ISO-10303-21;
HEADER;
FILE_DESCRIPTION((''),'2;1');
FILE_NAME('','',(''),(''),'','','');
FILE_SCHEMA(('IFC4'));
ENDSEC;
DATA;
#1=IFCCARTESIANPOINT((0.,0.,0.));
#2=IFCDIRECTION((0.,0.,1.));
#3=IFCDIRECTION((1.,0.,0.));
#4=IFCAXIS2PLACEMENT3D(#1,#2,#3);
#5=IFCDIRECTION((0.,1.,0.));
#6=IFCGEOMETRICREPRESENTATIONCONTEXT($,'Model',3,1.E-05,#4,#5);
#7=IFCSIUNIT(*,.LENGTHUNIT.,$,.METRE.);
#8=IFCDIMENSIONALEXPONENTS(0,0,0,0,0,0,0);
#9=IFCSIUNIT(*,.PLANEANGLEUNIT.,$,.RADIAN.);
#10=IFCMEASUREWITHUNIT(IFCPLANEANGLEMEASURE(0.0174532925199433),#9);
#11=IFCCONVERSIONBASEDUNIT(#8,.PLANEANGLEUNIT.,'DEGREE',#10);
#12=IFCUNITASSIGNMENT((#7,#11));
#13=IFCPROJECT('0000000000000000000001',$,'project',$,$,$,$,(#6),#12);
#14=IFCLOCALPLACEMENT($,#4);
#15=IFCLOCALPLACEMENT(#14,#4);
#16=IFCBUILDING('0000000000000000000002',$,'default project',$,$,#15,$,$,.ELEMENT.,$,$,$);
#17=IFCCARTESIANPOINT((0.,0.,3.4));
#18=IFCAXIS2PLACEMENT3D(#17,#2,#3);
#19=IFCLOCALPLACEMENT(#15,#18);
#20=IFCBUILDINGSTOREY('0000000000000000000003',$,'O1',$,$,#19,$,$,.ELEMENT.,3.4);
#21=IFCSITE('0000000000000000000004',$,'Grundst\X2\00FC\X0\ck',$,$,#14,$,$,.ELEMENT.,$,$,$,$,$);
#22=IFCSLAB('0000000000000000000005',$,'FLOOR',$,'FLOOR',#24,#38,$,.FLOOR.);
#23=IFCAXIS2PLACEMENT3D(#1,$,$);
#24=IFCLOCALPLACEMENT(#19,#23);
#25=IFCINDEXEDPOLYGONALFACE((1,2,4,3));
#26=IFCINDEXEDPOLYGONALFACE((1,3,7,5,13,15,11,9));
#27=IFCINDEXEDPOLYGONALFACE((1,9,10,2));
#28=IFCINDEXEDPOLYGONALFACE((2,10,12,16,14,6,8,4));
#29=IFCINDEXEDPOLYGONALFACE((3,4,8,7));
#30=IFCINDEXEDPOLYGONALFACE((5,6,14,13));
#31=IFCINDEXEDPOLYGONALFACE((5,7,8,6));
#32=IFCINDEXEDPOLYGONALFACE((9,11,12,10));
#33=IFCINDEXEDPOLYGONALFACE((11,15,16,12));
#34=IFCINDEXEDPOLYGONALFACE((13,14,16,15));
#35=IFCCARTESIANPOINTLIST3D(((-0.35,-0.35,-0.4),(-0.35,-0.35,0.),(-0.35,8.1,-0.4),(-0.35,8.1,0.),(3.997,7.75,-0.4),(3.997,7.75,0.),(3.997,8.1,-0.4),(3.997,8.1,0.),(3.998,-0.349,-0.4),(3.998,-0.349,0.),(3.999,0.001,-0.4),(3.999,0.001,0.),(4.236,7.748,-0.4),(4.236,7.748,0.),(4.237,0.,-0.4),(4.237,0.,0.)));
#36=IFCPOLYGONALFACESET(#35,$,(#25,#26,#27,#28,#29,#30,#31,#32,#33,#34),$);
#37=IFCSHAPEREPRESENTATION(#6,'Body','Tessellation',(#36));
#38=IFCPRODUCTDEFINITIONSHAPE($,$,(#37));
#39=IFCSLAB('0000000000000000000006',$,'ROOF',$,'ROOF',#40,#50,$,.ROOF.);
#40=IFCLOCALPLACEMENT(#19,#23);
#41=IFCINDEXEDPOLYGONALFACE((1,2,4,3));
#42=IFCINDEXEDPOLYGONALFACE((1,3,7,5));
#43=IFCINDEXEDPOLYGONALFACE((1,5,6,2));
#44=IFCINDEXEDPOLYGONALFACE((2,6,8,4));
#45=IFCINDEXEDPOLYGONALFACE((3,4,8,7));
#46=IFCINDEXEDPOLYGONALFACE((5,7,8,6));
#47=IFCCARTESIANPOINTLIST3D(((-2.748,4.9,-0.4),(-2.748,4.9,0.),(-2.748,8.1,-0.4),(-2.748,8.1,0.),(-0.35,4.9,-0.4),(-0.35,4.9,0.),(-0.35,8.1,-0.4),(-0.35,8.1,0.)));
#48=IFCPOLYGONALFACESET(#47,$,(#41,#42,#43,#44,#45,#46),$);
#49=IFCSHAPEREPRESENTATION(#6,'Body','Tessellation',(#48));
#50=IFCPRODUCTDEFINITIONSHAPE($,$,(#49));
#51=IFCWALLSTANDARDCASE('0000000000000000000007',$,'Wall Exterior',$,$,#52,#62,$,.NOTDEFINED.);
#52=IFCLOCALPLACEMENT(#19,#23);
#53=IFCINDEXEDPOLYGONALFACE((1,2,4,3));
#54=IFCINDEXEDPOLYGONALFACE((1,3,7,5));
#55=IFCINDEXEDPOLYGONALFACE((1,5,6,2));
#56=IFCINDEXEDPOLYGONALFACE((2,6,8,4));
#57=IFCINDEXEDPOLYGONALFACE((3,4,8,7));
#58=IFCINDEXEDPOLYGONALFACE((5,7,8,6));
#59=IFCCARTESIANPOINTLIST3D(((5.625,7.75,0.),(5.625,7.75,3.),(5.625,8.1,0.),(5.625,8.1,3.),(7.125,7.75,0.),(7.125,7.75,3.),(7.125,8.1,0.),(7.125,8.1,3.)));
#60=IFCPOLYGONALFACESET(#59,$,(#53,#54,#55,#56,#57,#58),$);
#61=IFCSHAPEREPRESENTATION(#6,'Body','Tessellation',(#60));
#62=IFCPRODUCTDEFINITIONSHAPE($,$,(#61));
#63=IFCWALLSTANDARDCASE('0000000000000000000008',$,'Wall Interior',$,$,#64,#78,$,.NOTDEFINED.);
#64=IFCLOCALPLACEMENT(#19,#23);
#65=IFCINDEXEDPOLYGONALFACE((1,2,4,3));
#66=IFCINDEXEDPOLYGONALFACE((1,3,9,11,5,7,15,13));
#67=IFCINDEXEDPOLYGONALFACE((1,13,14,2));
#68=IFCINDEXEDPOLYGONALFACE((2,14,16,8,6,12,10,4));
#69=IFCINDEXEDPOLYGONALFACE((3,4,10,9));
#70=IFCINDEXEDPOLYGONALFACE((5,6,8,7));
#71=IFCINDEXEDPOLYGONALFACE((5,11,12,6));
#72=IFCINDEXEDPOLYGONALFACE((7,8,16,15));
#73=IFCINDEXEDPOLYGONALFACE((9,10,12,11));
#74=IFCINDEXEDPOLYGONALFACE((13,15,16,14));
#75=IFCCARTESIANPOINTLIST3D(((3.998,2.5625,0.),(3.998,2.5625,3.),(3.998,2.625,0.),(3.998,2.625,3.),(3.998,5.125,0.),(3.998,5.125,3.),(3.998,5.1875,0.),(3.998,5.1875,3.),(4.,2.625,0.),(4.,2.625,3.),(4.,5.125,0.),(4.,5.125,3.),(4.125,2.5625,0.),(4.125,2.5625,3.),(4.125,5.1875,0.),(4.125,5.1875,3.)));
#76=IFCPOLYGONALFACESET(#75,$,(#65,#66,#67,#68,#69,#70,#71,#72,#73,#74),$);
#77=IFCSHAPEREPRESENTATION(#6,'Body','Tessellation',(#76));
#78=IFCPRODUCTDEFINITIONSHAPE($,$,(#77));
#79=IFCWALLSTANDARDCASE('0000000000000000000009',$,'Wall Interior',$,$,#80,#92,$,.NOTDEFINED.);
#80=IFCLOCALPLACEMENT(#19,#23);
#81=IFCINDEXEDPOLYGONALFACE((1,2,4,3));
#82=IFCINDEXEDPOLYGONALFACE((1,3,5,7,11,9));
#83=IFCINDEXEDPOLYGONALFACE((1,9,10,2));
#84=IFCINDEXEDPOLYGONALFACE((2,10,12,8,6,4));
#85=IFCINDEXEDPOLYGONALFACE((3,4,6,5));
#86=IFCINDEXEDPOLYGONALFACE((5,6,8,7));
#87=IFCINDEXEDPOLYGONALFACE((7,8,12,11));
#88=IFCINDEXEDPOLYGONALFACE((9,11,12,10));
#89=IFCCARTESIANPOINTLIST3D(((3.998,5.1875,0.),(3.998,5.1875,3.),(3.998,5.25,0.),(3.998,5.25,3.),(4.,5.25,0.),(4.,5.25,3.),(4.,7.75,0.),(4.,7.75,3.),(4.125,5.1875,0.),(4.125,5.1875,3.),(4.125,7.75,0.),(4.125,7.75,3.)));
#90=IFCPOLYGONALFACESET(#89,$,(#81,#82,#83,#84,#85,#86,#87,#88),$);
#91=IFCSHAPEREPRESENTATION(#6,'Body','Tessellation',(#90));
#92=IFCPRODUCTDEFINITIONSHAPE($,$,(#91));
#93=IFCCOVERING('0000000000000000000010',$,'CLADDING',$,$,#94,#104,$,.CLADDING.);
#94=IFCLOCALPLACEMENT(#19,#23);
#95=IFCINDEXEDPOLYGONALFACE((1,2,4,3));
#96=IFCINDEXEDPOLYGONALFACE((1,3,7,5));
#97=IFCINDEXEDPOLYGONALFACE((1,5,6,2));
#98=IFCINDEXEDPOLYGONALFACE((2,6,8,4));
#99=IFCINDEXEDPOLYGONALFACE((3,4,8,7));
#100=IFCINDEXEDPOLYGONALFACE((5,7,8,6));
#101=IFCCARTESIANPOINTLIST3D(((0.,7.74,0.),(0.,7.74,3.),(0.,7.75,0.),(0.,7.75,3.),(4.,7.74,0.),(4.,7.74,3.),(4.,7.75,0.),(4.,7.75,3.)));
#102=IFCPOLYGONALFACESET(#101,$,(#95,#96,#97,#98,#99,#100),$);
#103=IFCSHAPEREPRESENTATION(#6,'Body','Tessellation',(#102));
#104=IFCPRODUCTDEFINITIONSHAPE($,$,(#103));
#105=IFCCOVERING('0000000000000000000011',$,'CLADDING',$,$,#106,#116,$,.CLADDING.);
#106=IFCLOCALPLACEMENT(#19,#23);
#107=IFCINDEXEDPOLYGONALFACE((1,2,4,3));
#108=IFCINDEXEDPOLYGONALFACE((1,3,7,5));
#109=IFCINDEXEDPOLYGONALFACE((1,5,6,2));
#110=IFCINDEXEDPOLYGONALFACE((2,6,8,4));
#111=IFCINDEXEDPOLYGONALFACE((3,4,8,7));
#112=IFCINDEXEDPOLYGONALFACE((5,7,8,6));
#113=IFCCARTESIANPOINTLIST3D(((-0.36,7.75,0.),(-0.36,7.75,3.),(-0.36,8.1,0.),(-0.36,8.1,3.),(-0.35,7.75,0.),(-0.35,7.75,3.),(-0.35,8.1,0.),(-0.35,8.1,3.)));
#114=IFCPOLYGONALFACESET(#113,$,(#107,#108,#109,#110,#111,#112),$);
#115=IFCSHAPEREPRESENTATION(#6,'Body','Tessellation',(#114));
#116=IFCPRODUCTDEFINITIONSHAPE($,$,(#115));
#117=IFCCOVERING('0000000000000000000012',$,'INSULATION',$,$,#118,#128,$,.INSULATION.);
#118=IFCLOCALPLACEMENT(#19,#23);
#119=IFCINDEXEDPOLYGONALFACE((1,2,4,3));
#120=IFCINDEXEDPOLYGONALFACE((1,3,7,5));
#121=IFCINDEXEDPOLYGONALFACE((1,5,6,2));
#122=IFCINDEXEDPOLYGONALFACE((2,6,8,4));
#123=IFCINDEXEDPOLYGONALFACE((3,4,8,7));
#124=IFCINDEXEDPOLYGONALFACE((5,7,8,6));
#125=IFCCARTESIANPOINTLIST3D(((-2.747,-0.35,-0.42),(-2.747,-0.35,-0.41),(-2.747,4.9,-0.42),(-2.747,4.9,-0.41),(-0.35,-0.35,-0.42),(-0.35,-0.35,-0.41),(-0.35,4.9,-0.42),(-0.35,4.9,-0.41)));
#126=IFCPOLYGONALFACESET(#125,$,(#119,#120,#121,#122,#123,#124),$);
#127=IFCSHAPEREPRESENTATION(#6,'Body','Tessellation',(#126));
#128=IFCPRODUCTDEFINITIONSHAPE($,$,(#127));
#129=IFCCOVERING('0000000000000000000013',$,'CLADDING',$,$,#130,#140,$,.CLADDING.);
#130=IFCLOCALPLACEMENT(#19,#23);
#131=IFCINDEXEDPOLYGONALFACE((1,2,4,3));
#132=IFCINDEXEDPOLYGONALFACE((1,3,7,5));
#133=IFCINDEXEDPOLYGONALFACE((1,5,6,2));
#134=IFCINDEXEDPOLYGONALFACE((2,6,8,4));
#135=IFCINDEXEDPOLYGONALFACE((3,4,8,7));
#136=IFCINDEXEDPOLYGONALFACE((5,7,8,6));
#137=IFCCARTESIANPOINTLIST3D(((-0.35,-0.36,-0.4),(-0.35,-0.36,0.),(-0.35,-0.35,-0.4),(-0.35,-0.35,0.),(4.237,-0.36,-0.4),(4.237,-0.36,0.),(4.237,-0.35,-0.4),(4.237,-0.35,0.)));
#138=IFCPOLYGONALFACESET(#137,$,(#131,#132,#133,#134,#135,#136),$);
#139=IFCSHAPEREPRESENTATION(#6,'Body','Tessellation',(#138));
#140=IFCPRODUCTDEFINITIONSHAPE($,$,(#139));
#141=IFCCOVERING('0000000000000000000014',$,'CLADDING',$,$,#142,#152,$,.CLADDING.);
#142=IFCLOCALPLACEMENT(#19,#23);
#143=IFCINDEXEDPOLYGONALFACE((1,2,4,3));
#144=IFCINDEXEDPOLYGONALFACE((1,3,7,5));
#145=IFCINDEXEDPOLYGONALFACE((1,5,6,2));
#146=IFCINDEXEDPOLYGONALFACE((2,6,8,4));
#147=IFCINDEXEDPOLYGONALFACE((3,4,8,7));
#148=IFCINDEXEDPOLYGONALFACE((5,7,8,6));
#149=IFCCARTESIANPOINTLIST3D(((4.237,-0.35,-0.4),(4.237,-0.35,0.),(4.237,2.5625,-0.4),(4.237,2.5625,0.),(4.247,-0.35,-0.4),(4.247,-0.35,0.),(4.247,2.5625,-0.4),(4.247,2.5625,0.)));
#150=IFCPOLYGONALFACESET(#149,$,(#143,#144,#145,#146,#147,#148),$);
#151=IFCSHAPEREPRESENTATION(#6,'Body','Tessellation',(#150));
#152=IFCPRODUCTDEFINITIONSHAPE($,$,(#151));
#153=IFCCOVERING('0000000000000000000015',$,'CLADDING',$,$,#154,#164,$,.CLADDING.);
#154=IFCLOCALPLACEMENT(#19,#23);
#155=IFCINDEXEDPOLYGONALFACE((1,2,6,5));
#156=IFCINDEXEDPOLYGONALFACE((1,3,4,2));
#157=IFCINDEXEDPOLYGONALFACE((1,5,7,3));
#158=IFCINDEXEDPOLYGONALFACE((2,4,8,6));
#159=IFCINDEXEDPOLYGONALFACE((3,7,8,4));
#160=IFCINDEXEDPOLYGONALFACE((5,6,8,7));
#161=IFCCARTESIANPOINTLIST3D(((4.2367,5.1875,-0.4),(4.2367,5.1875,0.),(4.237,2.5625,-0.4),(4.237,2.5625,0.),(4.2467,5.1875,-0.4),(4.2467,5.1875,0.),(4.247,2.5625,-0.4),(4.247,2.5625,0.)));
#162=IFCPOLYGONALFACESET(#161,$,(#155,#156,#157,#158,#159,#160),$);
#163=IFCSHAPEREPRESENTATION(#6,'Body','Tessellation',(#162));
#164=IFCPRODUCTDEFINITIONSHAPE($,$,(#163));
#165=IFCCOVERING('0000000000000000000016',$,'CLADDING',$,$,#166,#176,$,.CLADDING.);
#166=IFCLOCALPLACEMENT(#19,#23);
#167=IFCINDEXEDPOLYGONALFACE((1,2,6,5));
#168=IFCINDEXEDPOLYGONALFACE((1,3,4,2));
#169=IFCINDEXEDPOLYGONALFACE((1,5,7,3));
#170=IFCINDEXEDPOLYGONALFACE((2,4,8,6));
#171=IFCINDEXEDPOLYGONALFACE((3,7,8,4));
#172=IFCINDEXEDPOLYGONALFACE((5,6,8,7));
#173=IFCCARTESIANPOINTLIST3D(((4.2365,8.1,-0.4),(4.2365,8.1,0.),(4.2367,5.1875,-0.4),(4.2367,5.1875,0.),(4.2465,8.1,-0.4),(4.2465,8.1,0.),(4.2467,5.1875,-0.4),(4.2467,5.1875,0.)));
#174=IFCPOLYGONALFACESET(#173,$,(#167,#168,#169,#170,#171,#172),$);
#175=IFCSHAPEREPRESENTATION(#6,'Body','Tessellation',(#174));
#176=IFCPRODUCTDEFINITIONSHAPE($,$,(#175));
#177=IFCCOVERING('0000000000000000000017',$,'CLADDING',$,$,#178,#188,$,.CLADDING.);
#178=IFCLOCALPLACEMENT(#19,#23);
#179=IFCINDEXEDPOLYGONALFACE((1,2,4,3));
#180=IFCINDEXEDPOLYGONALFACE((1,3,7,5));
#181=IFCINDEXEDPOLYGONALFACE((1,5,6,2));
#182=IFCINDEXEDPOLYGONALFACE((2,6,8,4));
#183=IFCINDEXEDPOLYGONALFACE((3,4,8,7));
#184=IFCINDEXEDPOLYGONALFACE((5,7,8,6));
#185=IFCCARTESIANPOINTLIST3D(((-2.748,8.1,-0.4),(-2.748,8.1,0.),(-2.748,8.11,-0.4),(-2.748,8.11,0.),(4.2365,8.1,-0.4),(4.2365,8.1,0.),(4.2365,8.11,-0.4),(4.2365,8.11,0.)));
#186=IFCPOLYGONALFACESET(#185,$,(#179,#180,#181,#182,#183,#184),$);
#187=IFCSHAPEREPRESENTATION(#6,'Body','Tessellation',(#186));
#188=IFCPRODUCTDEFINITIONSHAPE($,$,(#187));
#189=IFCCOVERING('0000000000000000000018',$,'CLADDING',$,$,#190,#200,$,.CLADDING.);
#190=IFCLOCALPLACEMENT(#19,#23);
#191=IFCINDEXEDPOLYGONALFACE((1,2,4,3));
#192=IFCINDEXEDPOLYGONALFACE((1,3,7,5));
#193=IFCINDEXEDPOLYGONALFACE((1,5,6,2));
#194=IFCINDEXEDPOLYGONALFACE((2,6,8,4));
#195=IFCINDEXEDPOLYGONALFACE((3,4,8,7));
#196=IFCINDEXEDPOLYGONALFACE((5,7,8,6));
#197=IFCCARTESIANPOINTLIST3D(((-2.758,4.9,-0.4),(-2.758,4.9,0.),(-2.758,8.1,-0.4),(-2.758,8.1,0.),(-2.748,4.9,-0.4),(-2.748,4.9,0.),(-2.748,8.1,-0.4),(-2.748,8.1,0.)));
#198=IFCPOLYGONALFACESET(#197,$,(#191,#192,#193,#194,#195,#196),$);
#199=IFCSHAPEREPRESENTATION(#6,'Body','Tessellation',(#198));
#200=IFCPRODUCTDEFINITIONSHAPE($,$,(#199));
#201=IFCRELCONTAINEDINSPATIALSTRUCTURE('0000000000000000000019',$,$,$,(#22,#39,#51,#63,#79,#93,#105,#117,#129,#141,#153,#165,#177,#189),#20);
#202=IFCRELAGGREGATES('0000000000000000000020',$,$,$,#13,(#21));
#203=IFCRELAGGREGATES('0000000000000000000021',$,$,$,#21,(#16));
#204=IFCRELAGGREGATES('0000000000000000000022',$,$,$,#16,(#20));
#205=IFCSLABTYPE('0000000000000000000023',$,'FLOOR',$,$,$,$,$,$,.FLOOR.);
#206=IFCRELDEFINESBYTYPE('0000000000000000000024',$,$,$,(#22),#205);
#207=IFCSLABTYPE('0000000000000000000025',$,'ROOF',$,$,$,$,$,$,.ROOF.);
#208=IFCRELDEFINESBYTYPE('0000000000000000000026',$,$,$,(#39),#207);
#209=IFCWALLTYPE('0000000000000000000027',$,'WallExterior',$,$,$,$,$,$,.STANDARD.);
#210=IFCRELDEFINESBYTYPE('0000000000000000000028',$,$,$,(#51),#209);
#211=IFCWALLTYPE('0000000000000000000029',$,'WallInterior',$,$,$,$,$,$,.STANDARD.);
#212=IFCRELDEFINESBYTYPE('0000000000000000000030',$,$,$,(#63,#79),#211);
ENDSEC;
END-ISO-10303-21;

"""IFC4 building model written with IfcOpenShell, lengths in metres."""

from ifc_helpers import new_model, entity, si_unit, converted_unit, direction, frame, origin_with_axes, place, context, project, spatial, polyline, outline, extrude, type_object, element, save


model = new_model("IFC4")

# Units and contexts
model_context = context("Model", 3, precision=1e-05, world=origin_with_axes(), true_north=direction((0.0, 1.0, 0.0)))
ifc_project = project(units=[si_unit("LENGTHUNIT", "METRE"), converted_unit("PLANEANGLEUNIT", "DEGREE", entity("IfcPlaneAngleMeasure", 0.0174532925199433), si_unit("PLANEANGLEUNIT", "RADIAN"), dimensions=[0, 0, 0, 0, 0, 0, 0])], contexts=[model_context])

# Site, building, storey
site_placement = place(None, origin_with_axes())
site = spatial("IfcSite", under=ifc_project, at=site_placement, Name="Grundstück", CompositionType="ELEMENT")
building_placement = place(site_placement, origin_with_axes())
building = spatial("IfcBuilding", under=site, at=building_placement, Name="default project", CompositionType="ELEMENT")
placement_1 = place(building_placement, frame((0.0, 0.0, 3.4), z_axis=(0.0, 0.0, 1.0), x_axis=(1.0, 0.0, 0.0)))
storey = spatial("IfcBuildingStorey", under=building, at=placement_1, Name="O1", CompositionType="ELEMENT", Elevation=3.4)

# Slabs
slab_type_1 = type_object("IfcSlabType", Name="FLOOR", PredefinedType="FLOOR")
slab_1_placement = place(placement_1, frame((0.0, 0.0, -0.4), z_axis=(0.0, 0.0, 1.0), x_axis=(1.0, 0.0, 0.0)))
element("IfcSlab", 1, at=slab_1_placement, inside=storey, type_object=slab_type_1, Name="FLOOR", ObjectType="FLOOR", PredefinedType="FLOOR", context=model_context, shape_type="SweptSolid", body=[
    extrude(outline(polyline([(4.237, 0.0), (4.236, 7.748), (3.997, 7.75), (3.997, 8.1), (-0.35, 8.1), (-0.35, -0.35), (3.998, -0.349), (3.999, 0.001), (4.237, 0.0)])), origin_with_axes(), (0.0, 0.0, 1.0), 0.4),
])
slab_type_2 = type_object("IfcSlabType", Name="ROOF", PredefinedType="ROOF")
slab_2_placement = place(placement_1, frame((0.0, 0.0, -0.4), z_axis=(0.0, 0.0, 1.0), x_axis=(1.0, 0.0, 0.0)))
element("IfcSlab", 2, at=slab_2_placement, inside=storey, type_object=slab_type_2, Name="ROOF", ObjectType="ROOF", PredefinedType="ROOF", context=model_context, shape_type="SweptSolid", body=[
    extrude(outline(polyline([(-0.35, 8.1), (-2.748, 8.1), (-2.748, 4.9), (-0.35, 4.9), (-0.35, 8.1)])), origin_with_axes(), (0.0, 0.0, 1.0), 0.4),
])

# Walls
wall_type_1 = type_object("IfcWallType", Name="WallExterior", PredefinedType="STANDARD")
placement_2 = place(placement_1, frame((5.625, 7.925, 0.0), z_axis=(0.0, 0.0, 1.0), x_axis=(1.0, 0.0, 0.0)))
element("IfcWallStandardCase", 3, at=placement_2, inside=storey, type_object=wall_type_1, Name="Wall Exterior", PredefinedType="NOTDEFINED", context=model_context, shape_type="SweptSolid", body=[
    extrude(outline(polyline([(1.5, 0.175), (0.0, 0.175), (0.0, -0.175), (1.5, -0.175), (1.5, 0.175)])), origin_with_axes(), (0.0, 0.0, 1.0), 3.0),
])
placement_3 = place(placement_1, frame((-0.175, 7.925, 0.0), z_axis=(0.0, 0.0, 1.0), x_axis=(1.0, 0.0, 0.0)))
wall_type_2 = type_object("IfcWallType", Name="WallInterior", PredefinedType="STANDARD")
wall_1_placement = place(placement_1, frame((4.0625, 2.5625, 0.0), z_axis=(0.0, 0.0, 1.0), x_axis=(0.0, 1.0, 0.0)))
element("IfcWallStandardCase", 4, at=wall_1_placement, inside=storey, type_object=wall_type_2, Name="Wall Interior", PredefinedType="NOTDEFINED", context=model_context, shape_type="SweptSolid", body=[
    extrude(outline(polyline([(2.5625, 0.0625), (0.0625, 0.0625), (0.0625, 0.0645), (0.0, 0.0645), (0.0, -0.0625), (2.625, -0.0625), (2.625, 0.0645), (2.5625, 0.0645), (2.5625, 0.0625)])), origin_with_axes(), (0.0, 0.0, 1.0), 3.0),
])
wall_2_placement = place(placement_1, frame((4.0625, 5.1875, 0.0), z_axis=(0.0, 0.0, 1.0), x_axis=(0.0, 1.0, 0.0)))
element("IfcWallStandardCase", 5, at=wall_2_placement, inside=storey, type_object=wall_type_2, Name="Wall Interior", PredefinedType="NOTDEFINED", context=model_context, shape_type="SweptSolid", body=[
    extrude(outline(polyline([(0.0625, 0.0645), (0.0, 0.0645), (0.0, -0.0625), (2.5625, -0.0625), (2.5625, 0.0625), (0.0625, 0.0625), (0.0625, 0.0645)])), origin_with_axes(), (0.0, 0.0, 1.0), 3.0),
])

# Coverings
element("IfcCovering", 6, at=placement_1, inside=storey, Name="CLADDING", PredefinedType="CLADDING", context=model_context, shape_type="SweptSolid", body=[
    extrude(outline(polyline([(0.0, 7.74), (4.0, 7.74), (4.0, 7.75), (0.0, 7.75), (0.0, 7.74)])), origin_with_axes(), (0.0, 0.0, 1.0), 3.0),
])
element("IfcCovering", 7, at=placement_3, inside=storey, Name="CLADDING", PredefinedType="CLADDING", context=model_context, shape_type="SweptSolid", body=[
    extrude(outline(polyline([(-0.185, 0.175), (-0.185, -0.175), (-0.175, -0.175), (-0.175, 0.175), (-0.185, 0.175)])), origin_with_axes(), (0.0, 0.0, 1.0), 3.0),
])
placement_4 = place(placement_1, frame((0.0, 0.0, -0.4), z_axis=(0.0, 0.0, 1.0), x_axis=(1.0, 0.0, 0.0)))
covering_1_placement = place(placement_4, frame((0.0, 0.0, -0.01), z_axis=(0.0, 0.0, 1.0), x_axis=(1.0, 0.0, 0.0)))
element("IfcCovering", 8, at=covering_1_placement, inside=storey, Name="INSULATION", PredefinedType="INSULATION", context=model_context, shape_type="SweptSolid", body=[
    extrude(outline(polyline([(-0.35, 4.9), (-2.747, 4.9), (-2.747, -0.35), (-0.35, -0.35), (-0.35, 4.9)])), frame((0.0, 0.0, -0.01), z_axis=(0.0, 0.0, 1.0), x_axis=(1.0, 0.0, 0.0)), (0.0, 0.0, 1.0), 0.01),
])
covering_2_placement = place(slab_1_placement, origin_with_axes())
element("IfcCovering", 9, at=covering_2_placement, inside=storey, Name="CLADDING", PredefinedType="CLADDING", context=model_context, shape_type="SweptSolid", body=[
    extrude(outline(polyline([(-0.35, -0.36), (4.237, -0.36), (4.237, -0.35), (-0.35, -0.35), (-0.35, -0.36)])), origin_with_axes(), (0.0, 0.0, 1.0), 0.4),
])
covering_3_placement = place(slab_1_placement, origin_with_axes())
element("IfcCovering", 10, at=covering_3_placement, inside=storey, Name="CLADDING", PredefinedType="CLADDING", context=model_context, shape_type="SweptSolid", body=[
    extrude(outline(polyline([(4.247, -0.35), (4.247, 2.5625), (4.237, 2.5625), (4.237, -0.35), (4.247, -0.35)])), origin_with_axes(), (0.0, 0.0, 1.0), 0.4),
])
covering_4_placement = place(slab_1_placement, origin_with_axes())
element("IfcCovering", 11, at=covering_4_placement, inside=storey, Name="CLADDING", PredefinedType="CLADDING", context=model_context, shape_type="SweptSolid", body=[
    extrude(outline(polyline([(4.247, 2.5625), (4.2467, 5.1875), (4.2367, 5.1875), (4.237, 2.5625), (4.247, 2.5625)])), origin_with_axes(), (0.0, 0.0, 1.0), 0.4),
])
covering_5_placement = place(slab_1_placement, origin_with_axes())
element("IfcCovering", 12, at=covering_5_placement, inside=storey, Name="CLADDING", PredefinedType="CLADDING", context=model_context, shape_type="SweptSolid", body=[
    extrude(outline(polyline([(4.2467, 5.1875), (4.2465, 8.1), (4.2365, 8.1), (4.2367, 5.1875), (4.2467, 5.1875)])), origin_with_axes(), (0.0, 0.0, 1.0), 0.4),
])
covering_6_placement = place(slab_1_placement, origin_with_axes())
element("IfcCovering", 13, at=covering_6_placement, inside=storey, Name="CLADDING", PredefinedType="CLADDING", context=model_context, shape_type="SweptSolid", body=[
    extrude(outline(polyline([(4.2365, 8.11), (-2.748, 8.11), (-2.748, 8.1), (4.2365, 8.1), (4.2365, 8.11)])), origin_with_axes(), (0.0, 0.0, 1.0), 0.4),
])
covering_7_placement = place(slab_1_placement, origin_with_axes())
element("IfcCovering", 14, at=covering_7_placement, inside=storey, Name="CLADDING", PredefinedType="CLADDING", context=model_context, shape_type="SweptSolid", body=[
    extrude(outline(polyline([(-2.758, 8.1), (-2.758, 4.9), (-2.748, 4.9), (-2.748, 8.1), (-2.758, 8.1)])), origin_with_axes(), (0.0, 0.0, 1.0), 0.4),
])

save(model, "model.ifc")
